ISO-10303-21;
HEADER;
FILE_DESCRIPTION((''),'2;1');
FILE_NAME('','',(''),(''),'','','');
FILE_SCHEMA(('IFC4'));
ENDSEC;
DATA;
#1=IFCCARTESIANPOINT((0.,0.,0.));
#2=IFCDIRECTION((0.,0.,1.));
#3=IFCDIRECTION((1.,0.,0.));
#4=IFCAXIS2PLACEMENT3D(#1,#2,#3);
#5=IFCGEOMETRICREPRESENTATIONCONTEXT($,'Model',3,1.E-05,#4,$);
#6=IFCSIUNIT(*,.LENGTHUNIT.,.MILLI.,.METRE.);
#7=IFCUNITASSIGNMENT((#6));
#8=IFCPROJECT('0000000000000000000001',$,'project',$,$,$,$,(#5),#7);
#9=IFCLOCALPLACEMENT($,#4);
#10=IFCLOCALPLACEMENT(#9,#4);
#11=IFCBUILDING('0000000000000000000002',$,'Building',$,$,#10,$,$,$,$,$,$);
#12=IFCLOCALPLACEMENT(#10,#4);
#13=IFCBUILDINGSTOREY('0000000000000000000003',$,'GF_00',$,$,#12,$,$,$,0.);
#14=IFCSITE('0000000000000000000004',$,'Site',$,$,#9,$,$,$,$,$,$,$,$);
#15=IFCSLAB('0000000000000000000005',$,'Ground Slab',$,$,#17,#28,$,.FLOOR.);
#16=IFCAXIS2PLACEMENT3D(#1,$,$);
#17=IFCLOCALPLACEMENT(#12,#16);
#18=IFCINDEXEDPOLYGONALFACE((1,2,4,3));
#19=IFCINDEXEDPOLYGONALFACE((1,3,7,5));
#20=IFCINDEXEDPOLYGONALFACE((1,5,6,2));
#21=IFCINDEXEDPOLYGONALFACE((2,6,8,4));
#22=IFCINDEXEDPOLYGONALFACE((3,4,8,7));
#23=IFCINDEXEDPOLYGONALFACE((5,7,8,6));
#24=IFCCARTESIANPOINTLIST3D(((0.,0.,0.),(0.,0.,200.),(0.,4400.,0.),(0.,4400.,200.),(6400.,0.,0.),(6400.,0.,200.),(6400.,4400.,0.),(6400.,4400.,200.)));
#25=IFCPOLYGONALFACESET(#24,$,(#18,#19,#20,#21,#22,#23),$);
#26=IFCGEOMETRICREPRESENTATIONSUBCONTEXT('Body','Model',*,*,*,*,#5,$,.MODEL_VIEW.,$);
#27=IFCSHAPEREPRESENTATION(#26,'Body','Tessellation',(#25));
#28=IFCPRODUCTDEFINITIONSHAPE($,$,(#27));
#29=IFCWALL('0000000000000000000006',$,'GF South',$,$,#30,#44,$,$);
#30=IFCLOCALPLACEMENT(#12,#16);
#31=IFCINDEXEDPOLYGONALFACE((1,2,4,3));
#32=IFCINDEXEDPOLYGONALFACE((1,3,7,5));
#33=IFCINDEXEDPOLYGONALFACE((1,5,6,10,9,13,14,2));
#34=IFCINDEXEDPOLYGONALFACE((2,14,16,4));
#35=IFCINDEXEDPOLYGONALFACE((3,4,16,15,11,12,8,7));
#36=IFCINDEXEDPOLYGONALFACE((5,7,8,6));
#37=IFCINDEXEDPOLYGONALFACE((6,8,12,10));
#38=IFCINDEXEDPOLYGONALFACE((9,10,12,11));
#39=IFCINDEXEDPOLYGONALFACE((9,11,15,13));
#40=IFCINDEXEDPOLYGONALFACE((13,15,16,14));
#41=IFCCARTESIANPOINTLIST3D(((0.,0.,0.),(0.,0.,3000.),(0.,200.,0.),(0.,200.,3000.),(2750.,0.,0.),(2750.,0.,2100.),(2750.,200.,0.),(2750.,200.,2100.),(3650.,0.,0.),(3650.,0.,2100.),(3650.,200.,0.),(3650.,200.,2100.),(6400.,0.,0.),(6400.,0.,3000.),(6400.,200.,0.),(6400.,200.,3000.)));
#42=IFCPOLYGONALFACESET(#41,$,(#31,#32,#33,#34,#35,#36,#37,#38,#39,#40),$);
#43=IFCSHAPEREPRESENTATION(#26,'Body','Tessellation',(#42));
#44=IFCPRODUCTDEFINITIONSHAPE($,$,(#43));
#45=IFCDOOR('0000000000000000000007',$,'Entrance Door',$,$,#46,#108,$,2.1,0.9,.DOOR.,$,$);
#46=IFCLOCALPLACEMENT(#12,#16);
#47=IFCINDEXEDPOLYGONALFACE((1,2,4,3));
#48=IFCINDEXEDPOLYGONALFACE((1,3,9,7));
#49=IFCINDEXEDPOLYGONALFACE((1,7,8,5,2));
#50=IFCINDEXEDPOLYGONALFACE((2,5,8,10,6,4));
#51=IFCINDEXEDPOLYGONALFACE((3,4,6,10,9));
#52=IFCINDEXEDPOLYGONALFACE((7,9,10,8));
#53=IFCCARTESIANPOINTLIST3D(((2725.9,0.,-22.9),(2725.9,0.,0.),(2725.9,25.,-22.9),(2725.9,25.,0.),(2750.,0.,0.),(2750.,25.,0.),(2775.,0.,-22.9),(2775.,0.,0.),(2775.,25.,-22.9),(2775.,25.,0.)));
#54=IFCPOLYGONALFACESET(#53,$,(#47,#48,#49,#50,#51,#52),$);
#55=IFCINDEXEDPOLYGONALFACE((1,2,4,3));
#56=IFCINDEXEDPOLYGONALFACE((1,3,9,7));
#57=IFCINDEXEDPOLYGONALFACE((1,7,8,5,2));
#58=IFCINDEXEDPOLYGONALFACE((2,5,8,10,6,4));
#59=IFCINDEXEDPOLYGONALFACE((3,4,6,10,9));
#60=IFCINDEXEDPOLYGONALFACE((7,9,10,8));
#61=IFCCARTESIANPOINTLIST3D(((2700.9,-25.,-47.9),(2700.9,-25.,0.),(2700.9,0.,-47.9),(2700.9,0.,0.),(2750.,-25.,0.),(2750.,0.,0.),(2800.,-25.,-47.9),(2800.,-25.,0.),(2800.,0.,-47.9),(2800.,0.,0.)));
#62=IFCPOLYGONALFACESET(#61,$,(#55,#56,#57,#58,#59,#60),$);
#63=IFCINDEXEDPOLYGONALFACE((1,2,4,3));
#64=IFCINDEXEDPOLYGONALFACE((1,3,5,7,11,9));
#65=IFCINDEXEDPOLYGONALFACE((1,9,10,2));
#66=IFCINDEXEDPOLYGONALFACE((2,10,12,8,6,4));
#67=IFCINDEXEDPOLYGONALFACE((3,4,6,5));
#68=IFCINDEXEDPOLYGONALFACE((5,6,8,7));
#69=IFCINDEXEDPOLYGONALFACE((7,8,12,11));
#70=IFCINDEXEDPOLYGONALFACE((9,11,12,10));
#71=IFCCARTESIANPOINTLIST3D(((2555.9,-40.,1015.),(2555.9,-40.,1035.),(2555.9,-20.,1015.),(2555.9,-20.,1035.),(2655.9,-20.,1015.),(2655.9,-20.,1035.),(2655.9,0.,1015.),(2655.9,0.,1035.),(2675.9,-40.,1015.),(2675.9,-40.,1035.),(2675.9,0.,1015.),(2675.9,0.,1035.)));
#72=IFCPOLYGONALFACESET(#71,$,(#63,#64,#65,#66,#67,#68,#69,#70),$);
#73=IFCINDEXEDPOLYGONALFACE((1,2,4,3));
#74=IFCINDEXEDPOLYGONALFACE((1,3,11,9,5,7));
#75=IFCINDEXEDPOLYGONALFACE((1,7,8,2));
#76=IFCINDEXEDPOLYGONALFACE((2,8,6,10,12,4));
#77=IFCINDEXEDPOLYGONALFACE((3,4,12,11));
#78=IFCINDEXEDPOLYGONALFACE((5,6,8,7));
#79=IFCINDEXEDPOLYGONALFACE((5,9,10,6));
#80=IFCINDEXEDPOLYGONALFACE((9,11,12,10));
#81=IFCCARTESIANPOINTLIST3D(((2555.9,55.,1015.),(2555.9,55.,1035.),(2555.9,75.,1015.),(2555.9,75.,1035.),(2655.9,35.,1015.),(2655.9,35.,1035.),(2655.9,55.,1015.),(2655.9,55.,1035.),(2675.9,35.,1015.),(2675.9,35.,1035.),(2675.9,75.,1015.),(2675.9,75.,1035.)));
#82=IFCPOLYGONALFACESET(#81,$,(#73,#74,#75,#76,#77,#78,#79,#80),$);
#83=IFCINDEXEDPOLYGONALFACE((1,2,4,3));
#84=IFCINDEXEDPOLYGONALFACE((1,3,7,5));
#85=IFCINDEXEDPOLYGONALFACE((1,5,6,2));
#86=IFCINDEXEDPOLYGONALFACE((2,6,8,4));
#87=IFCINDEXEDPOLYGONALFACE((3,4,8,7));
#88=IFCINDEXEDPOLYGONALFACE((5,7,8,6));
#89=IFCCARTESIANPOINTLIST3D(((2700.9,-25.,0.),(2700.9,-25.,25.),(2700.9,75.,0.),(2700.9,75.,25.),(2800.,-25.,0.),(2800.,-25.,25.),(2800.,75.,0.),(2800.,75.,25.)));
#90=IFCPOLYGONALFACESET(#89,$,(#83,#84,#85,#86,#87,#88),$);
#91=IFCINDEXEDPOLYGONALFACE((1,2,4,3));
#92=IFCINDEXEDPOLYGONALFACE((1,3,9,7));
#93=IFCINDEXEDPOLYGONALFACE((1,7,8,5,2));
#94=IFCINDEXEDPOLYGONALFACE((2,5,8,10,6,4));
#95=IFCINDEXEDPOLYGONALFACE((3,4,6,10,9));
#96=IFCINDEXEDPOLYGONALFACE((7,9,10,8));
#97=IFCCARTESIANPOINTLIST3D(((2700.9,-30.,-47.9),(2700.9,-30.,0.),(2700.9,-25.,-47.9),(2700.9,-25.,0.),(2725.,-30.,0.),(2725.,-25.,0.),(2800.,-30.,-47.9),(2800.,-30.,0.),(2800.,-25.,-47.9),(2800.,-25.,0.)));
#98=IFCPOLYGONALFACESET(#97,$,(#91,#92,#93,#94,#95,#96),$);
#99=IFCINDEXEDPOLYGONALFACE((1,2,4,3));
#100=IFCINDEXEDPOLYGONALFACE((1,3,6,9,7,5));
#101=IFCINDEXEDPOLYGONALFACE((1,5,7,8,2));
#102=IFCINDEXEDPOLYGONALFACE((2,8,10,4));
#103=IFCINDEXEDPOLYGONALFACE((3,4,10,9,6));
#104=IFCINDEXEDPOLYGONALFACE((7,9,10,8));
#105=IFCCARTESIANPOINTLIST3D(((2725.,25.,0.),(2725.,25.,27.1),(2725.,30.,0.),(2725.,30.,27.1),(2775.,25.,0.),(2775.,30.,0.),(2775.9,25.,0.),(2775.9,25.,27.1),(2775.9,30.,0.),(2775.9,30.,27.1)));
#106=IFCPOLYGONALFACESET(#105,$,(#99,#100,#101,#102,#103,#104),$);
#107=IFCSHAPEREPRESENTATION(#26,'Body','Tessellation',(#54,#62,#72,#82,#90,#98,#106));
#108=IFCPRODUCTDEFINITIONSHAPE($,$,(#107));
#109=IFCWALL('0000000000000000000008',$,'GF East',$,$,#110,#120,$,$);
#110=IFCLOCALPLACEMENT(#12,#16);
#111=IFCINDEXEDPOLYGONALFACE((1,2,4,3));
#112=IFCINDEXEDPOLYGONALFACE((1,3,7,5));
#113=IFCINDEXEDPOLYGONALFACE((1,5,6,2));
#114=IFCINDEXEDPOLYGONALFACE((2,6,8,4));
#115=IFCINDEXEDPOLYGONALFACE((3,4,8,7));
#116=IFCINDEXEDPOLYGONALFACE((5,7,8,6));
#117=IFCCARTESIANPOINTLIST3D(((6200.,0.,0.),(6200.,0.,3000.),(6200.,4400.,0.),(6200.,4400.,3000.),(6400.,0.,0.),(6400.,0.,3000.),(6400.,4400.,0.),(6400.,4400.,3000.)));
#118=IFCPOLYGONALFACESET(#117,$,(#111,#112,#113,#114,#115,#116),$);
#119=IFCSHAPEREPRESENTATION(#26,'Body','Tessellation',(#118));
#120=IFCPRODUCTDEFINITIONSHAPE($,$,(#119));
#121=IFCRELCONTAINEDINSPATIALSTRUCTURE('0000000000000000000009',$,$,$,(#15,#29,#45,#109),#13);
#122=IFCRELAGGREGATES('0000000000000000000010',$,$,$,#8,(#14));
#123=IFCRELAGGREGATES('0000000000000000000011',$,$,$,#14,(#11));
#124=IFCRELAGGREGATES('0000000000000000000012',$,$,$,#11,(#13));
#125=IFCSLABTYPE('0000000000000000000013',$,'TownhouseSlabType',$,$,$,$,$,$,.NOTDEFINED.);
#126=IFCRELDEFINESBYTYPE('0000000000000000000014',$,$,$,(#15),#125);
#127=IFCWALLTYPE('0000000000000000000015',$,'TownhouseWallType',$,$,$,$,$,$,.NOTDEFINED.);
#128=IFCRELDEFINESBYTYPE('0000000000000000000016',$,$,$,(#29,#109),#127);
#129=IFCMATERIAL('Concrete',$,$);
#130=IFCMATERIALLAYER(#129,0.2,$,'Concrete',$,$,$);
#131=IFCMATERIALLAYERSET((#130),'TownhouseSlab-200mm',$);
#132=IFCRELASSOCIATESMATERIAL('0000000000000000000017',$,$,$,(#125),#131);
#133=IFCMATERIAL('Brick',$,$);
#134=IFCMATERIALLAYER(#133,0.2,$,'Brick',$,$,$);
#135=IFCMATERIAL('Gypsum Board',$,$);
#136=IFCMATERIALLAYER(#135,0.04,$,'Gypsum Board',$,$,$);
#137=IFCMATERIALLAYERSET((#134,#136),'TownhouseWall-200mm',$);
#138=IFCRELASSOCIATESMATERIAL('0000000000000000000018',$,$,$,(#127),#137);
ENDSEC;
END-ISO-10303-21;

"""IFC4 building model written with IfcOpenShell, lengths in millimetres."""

from ifc_helpers import new_model, si_unit, frame, origin_with_axes, place, context, subcontext, project, spatial, line, indexed_curve, outline, extrude, material, layer, layer_set, type_object, element, fill, save


model = new_model("IFC4")

# Units and contexts
model_context = context("Model", 3, precision=1e-05, world=origin_with_axes())
body_context = subcontext(model_context, "Body", "Model", "MODEL_VIEW")
ifc_project = project(units=[si_unit("LENGTHUNIT", "METRE", prefix="MILLI")], contexts=[model_context])

# Site, building, storey
site_placement = place(None, origin_with_axes())
site = spatial("IfcSite", under=ifc_project, at=site_placement, Name="Site")
building_placement = place(site_placement, origin_with_axes())
building = spatial("IfcBuilding", under=site, at=building_placement, Name="Building")
storey_placement = place(building_placement, origin_with_axes())
storey = spatial("IfcBuildingStorey", under=building, at=storey_placement, Name="GF_00", Elevation=0.0)

# Slab
ifc_material_1 = material(Name="Concrete")
ifc_layer_1 = layer(ifc_material_1, 0.2, Name="Concrete")
ifc_layer_set_1 = layer_set([ifc_layer_1], Name="TownhouseSlab-200mm")
slab_type = type_object("IfcSlabType", Name="TownhouseSlabType", PredefinedType="NOTDEFINED", material=ifc_layer_set_1)
slab_placement = place(storey_placement, origin_with_axes())
element("IfcSlab", 1, at=slab_placement, inside=storey, type_object=slab_type, Name="Ground Slab", PredefinedType="FLOOR", context=body_context, shape_type="SweptSolid", body=[
    extrude(outline(indexed_curve([(0.0, 0.0), (6400.0, 0.0), (6400.0, 4400.0), (0.0, 4400.0), (0.0, 0.0)])), None, (0.0, 0.0, 1.0), 200.0),
])

# Wall, opening, door
ifc_material_2 = material(Name="Brick")
ifc_layer_2 = layer(ifc_material_2, 0.2, Name="Brick")
ifc_material_3 = material(Name="Gypsum Board")
ifc_layer_3 = layer(ifc_material_3, 0.04, Name="Gypsum Board")
ifc_layer_set_2 = layer_set([ifc_layer_2, ifc_layer_3], Name="TownhouseWall-200mm")
wall_type = type_object("IfcWallType", Name="TownhouseWallType", PredefinedType="NOTDEFINED", material=ifc_layer_set_2)
wall_1_placement = place(storey_placement, origin_with_axes())
wall_1 = element("IfcWall", 2, at=wall_1_placement, inside=storey, type_object=wall_type, Name="GF South", context=body_context, shape_type="SweptSolid", body=[
    extrude(outline(indexed_curve([(0.0, 0.0), (0.0, 200.0), (6400.0, 200.0), (6400.0, 0.0), (0.0, 0.0)], self_intersect=False)), origin_with_axes(), (0.0, 0.0, 1.0), 3000.0),
])
opening_1_placement = place(wall_1_placement, frame((2750.0, -25.0, 0.0), z_axis=(0.0, 0.0, 1.0), x_axis=(1.0, 0.0, 0.0)))
opening_1 = element("IfcOpeningElement", 3, at=opening_1_placement, cuts=wall_1, context=body_context, shape_type="SweptSolid", body=[
    extrude(outline(indexed_curve([(0.0, 0.0), (0.0, 250.0), (900.0, 250.0), (900.0, 0.0), (0.0, 0.0)], self_intersect=False)), origin_with_axes(), (0.0, 0.0, 1.0), 2100.0),
])
door_placement = place(storey_placement, frame((2750.0, -25.0, 0.0), z_axis=(0.0, 0.0, 1.0), x_axis=(1.0, 0.0, 0.0)))
door = element("IfcDoor", 4, at=door_placement, inside=storey, Name="Entrance Door", OverallHeight=2.1, OverallWidth=0.9, PredefinedType="DOOR", context=body_context, shape_type="SweptSolid", body=[
    extrude(outline(indexed_curve([(0.0, 0.0), (0.0, 2.1), (0.9, 2.1), (0.9, 0.0), (-24.1, 0.0), (-24.1, -22.9), (25.0, -22.9), (25.0, 0.0)], segments=[line(1, 2, 3, 4, 5, 6, 7, 8, 1)])), frame((0.0, 25.0, 0.0), z_axis=(0.0, -1.0, 0.0), x_axis=(1.0, 0.0, 0.0)), (0.0, 0.0, -1.0), 25.0),
    extrude(outline(indexed_curve([(0.0, 0.0), (0.0, 2.1), (0.9, 2.1), (0.9, 0.0), (-49.1, 0.0), (-49.1, -47.9), (50.0, -47.9), (50.0, 0.0)], segments=[line(1, 2, 3, 4, 5, 6, 7, 8, 1)])), frame((0.0, 0.0, 0.0), z_axis=(0.0, -1.0, 0.0), x_axis=(1.0, 0.0, 0.0)), (0.0, 0.0, -1.0), 25.0),
    extrude(outline(indexed_curve([(0.0, 0.0), (-49.1, 0.0), (-49.1, 35.0), (0.0, 35.0)], segments=[line(1, 2, 3, 4, 1)])), frame((25.0, 25.0, 25.0), z_axis=(0.0, 0.0, 1.0), x_axis=(1.0, 0.0, 0.0)), (0.0, 0.0, 1.0), -47.9),
    extrude(outline(indexed_curve([(0.0, 0.0), (0.0, -40.0), (-120.0, -40.0), (-120.0, -20.0), (-20.0, -20.0), (-20.0, 0.0)], segments=[line(1, 2, 3, 4, 5, 6, 1)])), frame((-74.1, 25.0, 1015.0), z_axis=(0.0, 0.0, 1.0), x_axis=(1.0, 0.0, 0.0)), (0.0, 0.0, 1.0), 20.0),
    extrude(outline(indexed_curve([(0.0, 0.0), (0.0, 40.0), (-120.0, 40.0), (-120.0, 20.0), (-20.0, 20.0), (-20.0, 0.0)], segments=[line(1, 2, 3, 4, 5, 6, 1)])), frame((-74.1, 60.0, 1015.0), z_axis=(0.0, 0.0, 1.0), x_axis=(1.0, 0.0, 0.0)), (0.0, 0.0, 1.0), 20.0),
    extrude(outline(indexed_curve([(0.0, 0.0), (-99.1, 0.0), (-99.1, 100.0), (0.0, 100.0)], segments=[line(1, 2, 3, 4, 1)])), frame((50.0, 0.0, 0.0), z_axis=(0.0, 0.0, 1.0), x_axis=(1.0, 0.0, 0.0)), (0.0, 0.0, 1.0), 25.0),
    extrude(outline(indexed_curve([(0.0, 0.0), (0.0, 27.1), (50.9, 27.1), (50.9, 0.0), (-24.1, 0.0), (-24.1, -47.9), (75.0, -47.9), (75.0, 0.0)], segments=[line(1, 2, 3, 4, 5, 6, 7, 8, 1)])), frame((-25.0, -5.0, 0.0), z_axis=(0.0, -1.0, 0.0), x_axis=(1.0, 0.0, 0.0)), (0.0, 0.0, -1.0), 5.0),
    extrude(outline(indexed_curve([(0.0, 0.0), (0.0, 27.1), (50.9, 27.1), (50.9, 0.0), (0.9, 0.0), (0.9, -22.9), (50.0, -22.9), (50.0, 0.0)], segments=[line(1, 2, 3, 4, 5, 6, 7, 8, 1)])), frame((-25.0, 50.0, 0.0), z_axis=(0.0, -1.0, 0.0), x_axis=(1.0, 0.0, 0.0)), (0.0, 0.0, -1.0), 5.0),
])
fill(opening_1, door)

# Wall
wall_2_placement = place(storey_placement, frame((6400.0, 0.0, 0.0), z_axis=(0.0, 0.0, 1.0), x_axis=(0.0, 1.0, 0.0)))
element("IfcWall", 5, at=wall_2_placement, inside=storey, type_object=wall_type, Name="GF East", context=body_context, shape_type="SweptSolid", body=[
    extrude(outline(indexed_curve([(0.0, 0.0), (0.0, 200.0), (4400.0, 200.0), (4400.0, 0.0), (0.0, 0.0)], self_intersect=False)), origin_with_axes(), (0.0, 0.0, 1.0), 3000.0),
])

save(model, "model.ifc")
